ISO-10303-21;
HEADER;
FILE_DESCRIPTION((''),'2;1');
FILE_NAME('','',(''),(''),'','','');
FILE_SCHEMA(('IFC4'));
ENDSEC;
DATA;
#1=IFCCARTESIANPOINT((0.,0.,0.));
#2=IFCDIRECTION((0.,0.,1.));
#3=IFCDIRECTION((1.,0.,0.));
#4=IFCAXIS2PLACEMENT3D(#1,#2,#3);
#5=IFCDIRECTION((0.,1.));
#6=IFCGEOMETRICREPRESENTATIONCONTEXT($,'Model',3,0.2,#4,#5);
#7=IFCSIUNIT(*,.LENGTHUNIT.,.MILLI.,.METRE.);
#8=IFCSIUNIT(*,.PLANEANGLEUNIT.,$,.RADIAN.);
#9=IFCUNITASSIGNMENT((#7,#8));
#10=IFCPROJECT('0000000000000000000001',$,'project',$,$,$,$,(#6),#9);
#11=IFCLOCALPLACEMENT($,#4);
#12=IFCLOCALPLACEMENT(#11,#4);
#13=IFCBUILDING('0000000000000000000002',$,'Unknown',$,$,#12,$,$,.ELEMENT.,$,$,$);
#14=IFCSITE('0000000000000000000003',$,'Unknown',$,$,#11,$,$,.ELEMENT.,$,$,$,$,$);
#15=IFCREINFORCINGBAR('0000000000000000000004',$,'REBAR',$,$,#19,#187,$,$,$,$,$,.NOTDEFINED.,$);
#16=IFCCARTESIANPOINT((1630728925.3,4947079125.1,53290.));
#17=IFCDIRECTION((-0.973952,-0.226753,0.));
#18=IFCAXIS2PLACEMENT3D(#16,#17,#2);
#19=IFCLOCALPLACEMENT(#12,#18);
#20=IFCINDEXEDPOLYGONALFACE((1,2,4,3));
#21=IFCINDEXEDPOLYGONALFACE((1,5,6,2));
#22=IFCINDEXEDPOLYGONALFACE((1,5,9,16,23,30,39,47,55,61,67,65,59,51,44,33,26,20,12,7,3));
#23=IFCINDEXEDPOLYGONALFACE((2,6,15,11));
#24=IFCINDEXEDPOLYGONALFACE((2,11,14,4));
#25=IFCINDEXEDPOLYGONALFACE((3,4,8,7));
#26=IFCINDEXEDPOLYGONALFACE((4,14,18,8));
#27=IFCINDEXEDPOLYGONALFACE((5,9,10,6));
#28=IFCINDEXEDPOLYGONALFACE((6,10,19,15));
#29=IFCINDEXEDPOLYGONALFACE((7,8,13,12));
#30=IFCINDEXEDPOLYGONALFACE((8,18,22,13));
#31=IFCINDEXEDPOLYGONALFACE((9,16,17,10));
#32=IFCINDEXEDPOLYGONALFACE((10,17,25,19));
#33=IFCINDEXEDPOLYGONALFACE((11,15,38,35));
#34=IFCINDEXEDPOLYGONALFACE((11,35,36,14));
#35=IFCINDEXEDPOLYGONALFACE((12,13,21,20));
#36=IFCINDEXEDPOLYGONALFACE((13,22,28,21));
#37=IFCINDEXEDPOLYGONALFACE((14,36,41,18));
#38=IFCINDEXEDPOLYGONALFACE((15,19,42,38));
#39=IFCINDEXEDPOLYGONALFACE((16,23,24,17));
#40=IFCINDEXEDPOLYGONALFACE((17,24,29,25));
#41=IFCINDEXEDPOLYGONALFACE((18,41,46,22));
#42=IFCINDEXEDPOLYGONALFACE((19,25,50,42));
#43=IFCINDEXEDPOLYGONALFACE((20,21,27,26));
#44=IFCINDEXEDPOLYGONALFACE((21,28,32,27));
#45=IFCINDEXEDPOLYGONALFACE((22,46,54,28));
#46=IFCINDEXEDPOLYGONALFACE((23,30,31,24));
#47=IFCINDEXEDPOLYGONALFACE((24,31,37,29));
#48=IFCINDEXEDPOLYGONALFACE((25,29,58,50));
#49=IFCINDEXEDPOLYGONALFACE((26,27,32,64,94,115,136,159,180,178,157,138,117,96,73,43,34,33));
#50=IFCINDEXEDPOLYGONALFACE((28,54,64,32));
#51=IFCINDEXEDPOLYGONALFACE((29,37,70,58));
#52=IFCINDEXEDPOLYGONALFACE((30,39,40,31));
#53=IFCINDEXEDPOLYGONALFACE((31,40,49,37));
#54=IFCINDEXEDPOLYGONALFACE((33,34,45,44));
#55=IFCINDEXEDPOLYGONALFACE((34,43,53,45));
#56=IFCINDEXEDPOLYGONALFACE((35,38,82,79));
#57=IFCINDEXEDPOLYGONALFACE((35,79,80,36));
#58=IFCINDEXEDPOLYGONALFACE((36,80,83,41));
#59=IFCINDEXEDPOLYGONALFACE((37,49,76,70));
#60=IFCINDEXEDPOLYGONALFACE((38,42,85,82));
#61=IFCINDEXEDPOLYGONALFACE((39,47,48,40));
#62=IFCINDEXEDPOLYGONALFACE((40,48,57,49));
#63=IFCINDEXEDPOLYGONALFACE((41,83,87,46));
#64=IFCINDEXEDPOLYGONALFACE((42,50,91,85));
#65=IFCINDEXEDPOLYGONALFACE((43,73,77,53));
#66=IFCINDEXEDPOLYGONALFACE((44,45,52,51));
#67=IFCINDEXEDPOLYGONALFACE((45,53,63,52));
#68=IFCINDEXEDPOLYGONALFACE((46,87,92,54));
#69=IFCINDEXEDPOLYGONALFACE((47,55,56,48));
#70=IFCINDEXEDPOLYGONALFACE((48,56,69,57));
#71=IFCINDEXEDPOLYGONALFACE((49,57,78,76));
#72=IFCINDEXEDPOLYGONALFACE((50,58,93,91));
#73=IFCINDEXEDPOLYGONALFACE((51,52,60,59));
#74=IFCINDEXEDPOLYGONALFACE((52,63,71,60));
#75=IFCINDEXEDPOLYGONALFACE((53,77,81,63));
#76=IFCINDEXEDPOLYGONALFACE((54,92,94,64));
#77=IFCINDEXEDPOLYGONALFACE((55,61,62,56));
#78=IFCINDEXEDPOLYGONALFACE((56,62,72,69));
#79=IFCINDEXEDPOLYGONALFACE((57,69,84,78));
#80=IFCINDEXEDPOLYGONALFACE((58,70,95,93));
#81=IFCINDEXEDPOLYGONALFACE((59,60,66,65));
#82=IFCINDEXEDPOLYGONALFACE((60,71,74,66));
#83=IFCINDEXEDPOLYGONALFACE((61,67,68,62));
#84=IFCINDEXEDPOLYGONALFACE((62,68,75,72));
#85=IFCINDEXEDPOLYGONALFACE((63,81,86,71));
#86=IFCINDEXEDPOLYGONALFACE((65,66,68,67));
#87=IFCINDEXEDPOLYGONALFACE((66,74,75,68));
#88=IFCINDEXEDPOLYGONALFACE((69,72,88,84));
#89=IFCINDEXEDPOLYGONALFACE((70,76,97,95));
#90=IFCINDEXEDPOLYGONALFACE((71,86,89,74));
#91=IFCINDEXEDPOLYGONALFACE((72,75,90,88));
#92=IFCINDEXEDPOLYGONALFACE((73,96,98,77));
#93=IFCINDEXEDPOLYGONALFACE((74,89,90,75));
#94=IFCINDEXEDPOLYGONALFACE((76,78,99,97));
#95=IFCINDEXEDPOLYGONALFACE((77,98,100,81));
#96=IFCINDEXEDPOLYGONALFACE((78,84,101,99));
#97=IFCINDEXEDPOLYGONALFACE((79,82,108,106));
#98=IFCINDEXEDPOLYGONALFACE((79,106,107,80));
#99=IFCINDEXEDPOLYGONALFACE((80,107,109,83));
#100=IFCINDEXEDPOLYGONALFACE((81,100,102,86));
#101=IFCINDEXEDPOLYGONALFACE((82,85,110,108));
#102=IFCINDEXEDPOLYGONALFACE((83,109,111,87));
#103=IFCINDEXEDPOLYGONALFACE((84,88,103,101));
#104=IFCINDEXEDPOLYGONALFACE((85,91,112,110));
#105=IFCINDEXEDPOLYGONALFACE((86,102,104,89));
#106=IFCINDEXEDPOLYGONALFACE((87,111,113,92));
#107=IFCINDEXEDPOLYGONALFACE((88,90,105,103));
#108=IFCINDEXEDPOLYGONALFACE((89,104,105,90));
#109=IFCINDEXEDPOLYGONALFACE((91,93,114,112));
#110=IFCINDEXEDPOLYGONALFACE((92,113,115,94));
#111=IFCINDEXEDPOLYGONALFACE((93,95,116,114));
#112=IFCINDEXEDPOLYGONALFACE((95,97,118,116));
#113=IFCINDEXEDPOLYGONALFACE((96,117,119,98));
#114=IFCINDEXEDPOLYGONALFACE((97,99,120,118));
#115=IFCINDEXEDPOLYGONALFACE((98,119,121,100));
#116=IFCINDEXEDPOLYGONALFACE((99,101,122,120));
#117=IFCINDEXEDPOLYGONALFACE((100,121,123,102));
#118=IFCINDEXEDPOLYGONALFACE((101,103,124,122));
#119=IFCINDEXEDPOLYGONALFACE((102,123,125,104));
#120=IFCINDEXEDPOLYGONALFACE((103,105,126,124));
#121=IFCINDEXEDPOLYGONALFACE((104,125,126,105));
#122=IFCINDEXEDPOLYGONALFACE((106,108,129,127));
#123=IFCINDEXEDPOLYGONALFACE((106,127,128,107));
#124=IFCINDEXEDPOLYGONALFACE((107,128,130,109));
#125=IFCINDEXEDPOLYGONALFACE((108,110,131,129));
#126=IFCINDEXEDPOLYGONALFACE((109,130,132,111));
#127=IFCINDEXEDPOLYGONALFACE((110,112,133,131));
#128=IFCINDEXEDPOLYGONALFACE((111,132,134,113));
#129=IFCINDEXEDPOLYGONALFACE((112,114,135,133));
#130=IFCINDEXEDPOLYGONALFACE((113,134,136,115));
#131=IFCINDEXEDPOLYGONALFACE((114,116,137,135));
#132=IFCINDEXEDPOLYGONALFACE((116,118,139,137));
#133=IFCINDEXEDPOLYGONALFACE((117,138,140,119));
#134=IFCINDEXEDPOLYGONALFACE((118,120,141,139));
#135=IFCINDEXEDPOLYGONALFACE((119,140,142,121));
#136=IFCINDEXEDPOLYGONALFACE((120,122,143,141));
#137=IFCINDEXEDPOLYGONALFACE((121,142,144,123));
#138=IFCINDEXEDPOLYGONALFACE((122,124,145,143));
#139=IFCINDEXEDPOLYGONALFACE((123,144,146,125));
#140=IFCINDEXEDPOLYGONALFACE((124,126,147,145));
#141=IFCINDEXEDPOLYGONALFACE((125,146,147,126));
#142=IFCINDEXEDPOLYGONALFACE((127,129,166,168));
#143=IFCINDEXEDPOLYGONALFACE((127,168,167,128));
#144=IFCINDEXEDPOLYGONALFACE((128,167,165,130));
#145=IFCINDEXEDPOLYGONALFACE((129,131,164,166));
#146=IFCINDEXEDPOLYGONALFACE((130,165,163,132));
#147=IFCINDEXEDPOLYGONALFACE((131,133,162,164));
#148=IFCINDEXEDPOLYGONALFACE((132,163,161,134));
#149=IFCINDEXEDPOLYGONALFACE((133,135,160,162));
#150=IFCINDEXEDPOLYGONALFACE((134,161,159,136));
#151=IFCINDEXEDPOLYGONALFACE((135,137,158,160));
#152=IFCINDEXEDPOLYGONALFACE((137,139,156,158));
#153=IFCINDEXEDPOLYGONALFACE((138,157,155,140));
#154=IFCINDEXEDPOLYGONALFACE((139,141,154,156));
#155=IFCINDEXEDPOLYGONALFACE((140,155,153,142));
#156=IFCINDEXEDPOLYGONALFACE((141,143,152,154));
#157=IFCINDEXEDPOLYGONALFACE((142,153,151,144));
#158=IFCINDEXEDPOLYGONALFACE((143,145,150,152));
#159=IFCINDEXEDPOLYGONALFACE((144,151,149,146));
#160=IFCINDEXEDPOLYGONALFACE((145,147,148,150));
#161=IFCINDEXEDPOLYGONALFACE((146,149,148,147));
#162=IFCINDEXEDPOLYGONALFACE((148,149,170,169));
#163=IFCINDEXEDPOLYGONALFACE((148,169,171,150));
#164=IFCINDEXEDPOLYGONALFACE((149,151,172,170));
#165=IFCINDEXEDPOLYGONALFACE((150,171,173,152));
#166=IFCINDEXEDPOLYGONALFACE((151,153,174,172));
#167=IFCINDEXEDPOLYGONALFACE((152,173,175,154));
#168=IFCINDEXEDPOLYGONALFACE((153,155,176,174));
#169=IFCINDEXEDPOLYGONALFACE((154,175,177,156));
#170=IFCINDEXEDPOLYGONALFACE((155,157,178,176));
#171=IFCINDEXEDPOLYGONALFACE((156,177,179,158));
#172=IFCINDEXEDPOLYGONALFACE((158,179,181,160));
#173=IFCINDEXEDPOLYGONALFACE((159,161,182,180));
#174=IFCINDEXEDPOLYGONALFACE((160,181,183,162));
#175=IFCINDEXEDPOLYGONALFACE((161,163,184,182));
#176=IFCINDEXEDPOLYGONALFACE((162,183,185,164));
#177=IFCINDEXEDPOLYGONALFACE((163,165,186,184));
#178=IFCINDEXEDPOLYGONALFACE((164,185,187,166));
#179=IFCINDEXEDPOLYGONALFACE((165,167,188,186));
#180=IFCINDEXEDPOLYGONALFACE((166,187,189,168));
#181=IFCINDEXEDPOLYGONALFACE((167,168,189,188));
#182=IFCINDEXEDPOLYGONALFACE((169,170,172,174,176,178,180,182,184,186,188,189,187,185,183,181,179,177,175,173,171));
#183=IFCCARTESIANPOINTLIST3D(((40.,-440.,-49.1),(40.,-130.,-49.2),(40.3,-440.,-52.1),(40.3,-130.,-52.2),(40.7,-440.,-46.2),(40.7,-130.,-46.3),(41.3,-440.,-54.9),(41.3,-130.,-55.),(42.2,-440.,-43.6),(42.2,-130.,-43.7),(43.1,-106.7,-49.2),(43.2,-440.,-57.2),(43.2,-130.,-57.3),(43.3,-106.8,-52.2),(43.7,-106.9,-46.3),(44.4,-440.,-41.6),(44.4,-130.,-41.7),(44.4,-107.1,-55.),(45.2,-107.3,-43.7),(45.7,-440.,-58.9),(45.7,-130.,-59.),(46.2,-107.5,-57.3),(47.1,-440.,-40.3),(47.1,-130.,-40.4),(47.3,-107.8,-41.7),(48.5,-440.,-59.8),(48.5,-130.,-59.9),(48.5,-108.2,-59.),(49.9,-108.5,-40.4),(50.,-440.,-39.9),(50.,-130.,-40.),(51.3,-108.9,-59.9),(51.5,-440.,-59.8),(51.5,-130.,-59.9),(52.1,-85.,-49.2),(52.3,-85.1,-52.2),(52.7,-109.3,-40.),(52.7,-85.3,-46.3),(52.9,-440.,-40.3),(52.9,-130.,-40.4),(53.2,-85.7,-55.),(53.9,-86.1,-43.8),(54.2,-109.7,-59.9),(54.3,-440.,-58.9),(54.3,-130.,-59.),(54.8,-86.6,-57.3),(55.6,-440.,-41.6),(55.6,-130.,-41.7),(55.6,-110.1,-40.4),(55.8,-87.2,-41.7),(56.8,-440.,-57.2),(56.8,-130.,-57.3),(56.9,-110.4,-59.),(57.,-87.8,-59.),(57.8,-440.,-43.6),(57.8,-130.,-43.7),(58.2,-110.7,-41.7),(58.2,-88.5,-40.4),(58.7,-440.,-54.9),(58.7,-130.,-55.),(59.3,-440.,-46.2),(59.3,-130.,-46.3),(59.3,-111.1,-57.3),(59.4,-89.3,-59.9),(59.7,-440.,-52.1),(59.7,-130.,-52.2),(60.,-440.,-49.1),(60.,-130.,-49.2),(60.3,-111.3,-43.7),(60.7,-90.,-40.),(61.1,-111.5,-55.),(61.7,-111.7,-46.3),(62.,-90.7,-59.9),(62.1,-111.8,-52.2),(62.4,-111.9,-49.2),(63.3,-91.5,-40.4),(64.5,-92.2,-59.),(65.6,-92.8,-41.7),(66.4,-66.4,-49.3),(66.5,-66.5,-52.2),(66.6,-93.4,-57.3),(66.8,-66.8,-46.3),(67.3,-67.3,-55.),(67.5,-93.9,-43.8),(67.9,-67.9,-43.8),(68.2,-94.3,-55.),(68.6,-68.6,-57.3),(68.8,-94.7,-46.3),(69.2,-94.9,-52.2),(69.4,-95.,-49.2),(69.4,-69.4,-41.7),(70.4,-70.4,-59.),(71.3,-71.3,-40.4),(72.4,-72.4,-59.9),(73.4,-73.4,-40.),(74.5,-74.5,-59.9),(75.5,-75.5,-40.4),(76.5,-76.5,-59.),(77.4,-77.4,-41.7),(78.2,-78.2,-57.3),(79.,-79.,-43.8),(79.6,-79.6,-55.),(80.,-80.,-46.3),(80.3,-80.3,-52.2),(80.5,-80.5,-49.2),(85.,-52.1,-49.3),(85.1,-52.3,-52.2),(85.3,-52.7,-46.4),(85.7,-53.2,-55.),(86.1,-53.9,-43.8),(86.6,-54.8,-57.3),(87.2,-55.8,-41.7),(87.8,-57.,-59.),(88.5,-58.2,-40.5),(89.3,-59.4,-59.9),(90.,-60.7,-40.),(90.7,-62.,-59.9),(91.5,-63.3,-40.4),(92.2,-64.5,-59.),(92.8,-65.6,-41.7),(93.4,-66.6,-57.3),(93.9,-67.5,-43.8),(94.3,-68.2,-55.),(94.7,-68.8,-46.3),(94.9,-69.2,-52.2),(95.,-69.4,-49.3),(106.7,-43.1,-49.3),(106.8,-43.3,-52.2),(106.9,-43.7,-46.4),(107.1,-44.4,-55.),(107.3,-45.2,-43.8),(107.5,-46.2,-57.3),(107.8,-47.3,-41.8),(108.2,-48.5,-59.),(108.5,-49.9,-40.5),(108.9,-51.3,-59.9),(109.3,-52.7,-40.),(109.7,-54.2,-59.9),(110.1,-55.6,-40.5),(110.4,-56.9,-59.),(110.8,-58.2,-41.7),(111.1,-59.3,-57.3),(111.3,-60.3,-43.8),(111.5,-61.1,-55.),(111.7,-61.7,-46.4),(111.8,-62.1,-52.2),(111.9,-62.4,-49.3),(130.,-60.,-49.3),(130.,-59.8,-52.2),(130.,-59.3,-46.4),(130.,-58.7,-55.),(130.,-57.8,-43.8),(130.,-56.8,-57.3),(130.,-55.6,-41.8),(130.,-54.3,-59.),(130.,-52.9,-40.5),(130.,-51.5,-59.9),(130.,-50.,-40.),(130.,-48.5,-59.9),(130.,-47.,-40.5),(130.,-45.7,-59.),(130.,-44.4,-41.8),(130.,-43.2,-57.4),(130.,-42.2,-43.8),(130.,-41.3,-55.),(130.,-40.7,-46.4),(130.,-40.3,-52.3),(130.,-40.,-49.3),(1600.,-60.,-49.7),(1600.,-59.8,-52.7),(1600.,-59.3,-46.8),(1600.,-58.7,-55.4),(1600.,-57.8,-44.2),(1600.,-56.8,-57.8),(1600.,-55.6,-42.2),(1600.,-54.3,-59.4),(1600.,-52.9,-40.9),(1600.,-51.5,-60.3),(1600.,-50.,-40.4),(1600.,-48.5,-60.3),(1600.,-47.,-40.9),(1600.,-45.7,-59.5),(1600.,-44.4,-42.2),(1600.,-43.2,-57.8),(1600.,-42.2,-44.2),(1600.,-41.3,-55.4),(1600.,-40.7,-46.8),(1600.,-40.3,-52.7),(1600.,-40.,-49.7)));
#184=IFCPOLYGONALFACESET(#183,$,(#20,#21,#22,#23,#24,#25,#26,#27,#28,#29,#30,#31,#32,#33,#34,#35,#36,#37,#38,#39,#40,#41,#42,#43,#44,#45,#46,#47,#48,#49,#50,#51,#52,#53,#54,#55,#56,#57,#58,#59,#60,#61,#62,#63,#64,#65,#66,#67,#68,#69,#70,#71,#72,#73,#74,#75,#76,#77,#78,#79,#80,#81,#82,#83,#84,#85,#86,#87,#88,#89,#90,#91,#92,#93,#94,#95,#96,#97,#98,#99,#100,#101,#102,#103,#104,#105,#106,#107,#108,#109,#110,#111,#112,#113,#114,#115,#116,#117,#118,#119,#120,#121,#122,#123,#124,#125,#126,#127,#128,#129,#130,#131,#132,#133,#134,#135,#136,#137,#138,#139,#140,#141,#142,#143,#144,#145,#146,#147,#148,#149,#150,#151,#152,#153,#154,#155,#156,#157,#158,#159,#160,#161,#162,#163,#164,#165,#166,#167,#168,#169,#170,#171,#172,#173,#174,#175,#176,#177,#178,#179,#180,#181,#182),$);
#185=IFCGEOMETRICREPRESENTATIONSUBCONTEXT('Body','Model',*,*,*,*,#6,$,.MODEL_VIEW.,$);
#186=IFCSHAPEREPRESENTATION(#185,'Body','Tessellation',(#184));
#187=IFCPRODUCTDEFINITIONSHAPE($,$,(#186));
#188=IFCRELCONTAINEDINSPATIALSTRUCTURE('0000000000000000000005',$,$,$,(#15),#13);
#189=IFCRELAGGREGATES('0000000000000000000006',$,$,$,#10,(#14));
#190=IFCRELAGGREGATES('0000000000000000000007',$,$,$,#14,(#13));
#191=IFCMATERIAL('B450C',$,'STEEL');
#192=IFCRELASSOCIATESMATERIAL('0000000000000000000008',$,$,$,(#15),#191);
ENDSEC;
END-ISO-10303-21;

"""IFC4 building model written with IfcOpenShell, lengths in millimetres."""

from ifc_helpers import new_model, entity, si_unit, direction, frame, origin_with_axes, place, context, subcontext, project, spatial, material, element, save


model = new_model("IFC4")

# Units and contexts
model_context = context("Model", 3, precision=0.2, world=origin_with_axes(), true_north=direction((0.0, 1.0)))
body_context = subcontext(model_context, "Body", "Model", "MODEL_VIEW")
ifc_project = project(units=[si_unit("LENGTHUNIT", "METRE", prefix="MILLI"), si_unit("PLANEANGLEUNIT", "RADIAN")], contexts=[model_context])

# Site, building
site_placement = place(None, origin_with_axes())
site = spatial("IfcSite", under=ifc_project, at=site_placement, Name="Unknown", CompositionType="ELEMENT")
building_placement = place(site_placement, origin_with_axes())
building = spatial("IfcBuilding", under=site, at=building_placement, Name="Unknown", CompositionType="ELEMENT")

# Reinforcing bar
ifc_material = material(Name="B450C", Category="STEEL")
reinforcing_bar_1_placement = place(building_placement, frame((1630728925.3, 4947079125.1, 53290.0), z_axis=(-0.973952, -0.226753, 0.0), x_axis=(0.0, 0.0, 1.0)))
element("IfcReinforcingBar", 1, at=reinforcing_bar_1_placement, inside=building, material=ifc_material, Name="REBAR", PredefinedType="NOTDEFINED", context=body_context, shape_type="AdvancedSweptSolid", body=[
    entity("IfcSweptDiskSolid", entity("IfcIndexedPolyCurve", entity("IfcCartesianPointList3D", [[50.0, -440.0, -49.9], [50.0, -130.0, -50.0], [73.4, -73.4, -50.0], [130.0, -50.0, -50.0], [1600.0, -50.0, -50.4]]), [entity("IfcLineIndex", [1, 2]), entity("IfcArcIndex", [2, 3, 4]), entity("IfcLineIndex", [4, 5])]), 10.0),
])

save(model, "model.ifc")
